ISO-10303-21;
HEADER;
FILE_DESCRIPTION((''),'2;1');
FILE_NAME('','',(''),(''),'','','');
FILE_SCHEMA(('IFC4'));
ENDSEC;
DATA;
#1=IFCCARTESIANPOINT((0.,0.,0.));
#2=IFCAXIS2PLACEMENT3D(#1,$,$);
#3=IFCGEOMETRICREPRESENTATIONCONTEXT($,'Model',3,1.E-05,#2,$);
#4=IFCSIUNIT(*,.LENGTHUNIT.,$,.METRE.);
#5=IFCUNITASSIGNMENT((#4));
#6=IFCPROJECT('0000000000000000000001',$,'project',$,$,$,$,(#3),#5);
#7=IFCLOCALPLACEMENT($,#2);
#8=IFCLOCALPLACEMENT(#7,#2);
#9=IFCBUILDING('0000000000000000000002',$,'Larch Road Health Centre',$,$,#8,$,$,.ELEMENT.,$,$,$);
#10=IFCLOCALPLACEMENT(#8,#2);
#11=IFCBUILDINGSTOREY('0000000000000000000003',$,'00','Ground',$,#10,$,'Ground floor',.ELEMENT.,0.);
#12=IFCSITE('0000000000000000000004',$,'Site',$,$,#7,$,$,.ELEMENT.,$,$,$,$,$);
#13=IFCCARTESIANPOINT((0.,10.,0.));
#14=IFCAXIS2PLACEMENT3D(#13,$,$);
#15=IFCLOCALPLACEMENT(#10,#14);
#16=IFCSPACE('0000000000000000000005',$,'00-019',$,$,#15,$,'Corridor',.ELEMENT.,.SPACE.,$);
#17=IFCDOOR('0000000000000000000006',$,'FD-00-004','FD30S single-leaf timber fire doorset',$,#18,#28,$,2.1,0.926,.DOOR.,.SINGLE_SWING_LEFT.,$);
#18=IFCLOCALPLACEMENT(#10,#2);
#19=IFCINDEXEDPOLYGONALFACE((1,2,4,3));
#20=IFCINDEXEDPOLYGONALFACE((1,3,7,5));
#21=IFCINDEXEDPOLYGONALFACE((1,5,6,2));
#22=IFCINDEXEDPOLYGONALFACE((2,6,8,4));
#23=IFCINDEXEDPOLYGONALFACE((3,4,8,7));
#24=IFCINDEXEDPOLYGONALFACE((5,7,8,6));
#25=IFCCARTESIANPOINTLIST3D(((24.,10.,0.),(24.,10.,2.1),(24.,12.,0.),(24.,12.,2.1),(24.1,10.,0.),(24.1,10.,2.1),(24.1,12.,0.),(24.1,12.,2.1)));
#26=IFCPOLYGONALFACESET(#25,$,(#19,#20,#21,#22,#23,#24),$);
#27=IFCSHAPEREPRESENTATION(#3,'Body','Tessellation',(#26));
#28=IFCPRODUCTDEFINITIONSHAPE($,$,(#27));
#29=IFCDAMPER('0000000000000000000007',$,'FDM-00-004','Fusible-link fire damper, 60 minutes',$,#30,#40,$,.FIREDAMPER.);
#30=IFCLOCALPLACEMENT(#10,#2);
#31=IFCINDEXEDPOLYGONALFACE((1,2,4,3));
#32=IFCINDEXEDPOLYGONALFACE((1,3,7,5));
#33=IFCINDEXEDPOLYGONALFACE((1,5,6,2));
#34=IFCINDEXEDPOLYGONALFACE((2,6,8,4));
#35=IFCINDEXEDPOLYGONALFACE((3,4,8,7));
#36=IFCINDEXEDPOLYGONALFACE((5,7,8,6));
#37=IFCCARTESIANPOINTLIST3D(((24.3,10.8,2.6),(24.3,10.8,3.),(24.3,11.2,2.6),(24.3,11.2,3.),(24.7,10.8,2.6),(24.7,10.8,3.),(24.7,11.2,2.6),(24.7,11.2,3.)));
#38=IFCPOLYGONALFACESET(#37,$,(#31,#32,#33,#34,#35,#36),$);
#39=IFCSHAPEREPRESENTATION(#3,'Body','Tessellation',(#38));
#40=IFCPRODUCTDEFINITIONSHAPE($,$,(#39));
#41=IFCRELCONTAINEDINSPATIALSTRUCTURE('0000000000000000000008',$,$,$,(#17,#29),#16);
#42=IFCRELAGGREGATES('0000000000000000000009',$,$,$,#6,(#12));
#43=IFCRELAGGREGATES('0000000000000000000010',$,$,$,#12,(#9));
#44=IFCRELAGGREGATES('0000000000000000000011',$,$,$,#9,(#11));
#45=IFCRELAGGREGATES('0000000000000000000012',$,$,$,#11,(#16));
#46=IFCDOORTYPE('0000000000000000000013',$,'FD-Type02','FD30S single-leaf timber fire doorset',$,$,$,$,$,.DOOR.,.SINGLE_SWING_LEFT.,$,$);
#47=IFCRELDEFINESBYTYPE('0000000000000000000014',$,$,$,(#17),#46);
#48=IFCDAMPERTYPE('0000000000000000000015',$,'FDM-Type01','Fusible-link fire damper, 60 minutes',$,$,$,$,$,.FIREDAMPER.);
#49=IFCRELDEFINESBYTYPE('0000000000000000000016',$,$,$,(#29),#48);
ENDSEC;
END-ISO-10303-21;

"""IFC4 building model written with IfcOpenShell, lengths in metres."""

from ifc_helpers import new_model, si_unit, frame, frame_2d, origin, place, context, project, spatial, rectangle, extrude, type_object, element, save


model = new_model("IFC4")

# Units and contexts
model_context = context("Model", 3, precision=1e-05, world=origin())
ifc_project = project(units=[si_unit("LENGTHUNIT", "METRE")], contexts=[model_context])

# Site, building, storey
site_placement = place(None, origin())
site = spatial("IfcSite", under=ifc_project, at=site_placement, Name="Site", CompositionType="ELEMENT")
building_placement = place(site_placement, origin())
building = spatial("IfcBuilding", under=site, at=building_placement, Name="Larch Road Health Centre", CompositionType="ELEMENT")
storey_placement = place(building_placement, origin())
storey = spatial("IfcBuildingStorey", under=building, at=storey_placement, Name="00", Description="Ground", LongName="Ground floor", CompositionType="ELEMENT", Elevation=0.0)

# Shared definitions
door_type_1 = type_object("IfcDoorType", Name="FD-Type02", Description="FD30S single-leaf timber fire doorset", OperationType="SINGLE_SWING_LEFT", PredefinedType="DOOR")

# Shared definitions
space_1_placement = place(storey_placement, frame((0.0, 10.0, 0.0)))
space_1 = spatial("IfcSpace", under=storey, at=space_1_placement, Name="00-019", LongName="Corridor", CompositionType="ELEMENT", PredefinedType="SPACE")

# Door
door_1_placement = place(space_1_placement, frame((24.0, 0.0, 0.0)))
element("IfcDoor", 1, at=door_1_placement, inside=space_1, type_object=door_type_1, Name="FD-00-004", Description="FD30S single-leaf timber fire doorset", OperationType="SINGLE_SWING_LEFT", OverallHeight=2.1, OverallWidth=0.926, PredefinedType="DOOR", context=model_context, shape_type="SweptSolid", body=[
    extrude(rectangle(XDim=0.1, YDim=2.0, at=frame_2d((0.05, 1.0))), origin(), (0.0, 0.0, 1.0), 2.1),
])

# Damper
damper_type = type_object("IfcDamperType", Name="FDM-Type01", Description="Fusible-link fire damper, 60 minutes", PredefinedType="FIREDAMPER")
damper_placement = place(space_1_placement, frame((24.3, 0.8, 2.6)))
element("IfcDamper", 2, at=damper_placement, inside=space_1, type_object=damper_type, Name="FDM-00-004", Description="Fusible-link fire damper, 60 minutes", PredefinedType="FIREDAMPER", context=model_context, shape_type="SweptSolid", body=[
    extrude(rectangle(XDim=0.4, YDim=0.4, at=frame_2d((0.2, 0.2))), origin(), (0.0, 0.0, 1.0), 0.4),
])

save(model, "model.ifc")
